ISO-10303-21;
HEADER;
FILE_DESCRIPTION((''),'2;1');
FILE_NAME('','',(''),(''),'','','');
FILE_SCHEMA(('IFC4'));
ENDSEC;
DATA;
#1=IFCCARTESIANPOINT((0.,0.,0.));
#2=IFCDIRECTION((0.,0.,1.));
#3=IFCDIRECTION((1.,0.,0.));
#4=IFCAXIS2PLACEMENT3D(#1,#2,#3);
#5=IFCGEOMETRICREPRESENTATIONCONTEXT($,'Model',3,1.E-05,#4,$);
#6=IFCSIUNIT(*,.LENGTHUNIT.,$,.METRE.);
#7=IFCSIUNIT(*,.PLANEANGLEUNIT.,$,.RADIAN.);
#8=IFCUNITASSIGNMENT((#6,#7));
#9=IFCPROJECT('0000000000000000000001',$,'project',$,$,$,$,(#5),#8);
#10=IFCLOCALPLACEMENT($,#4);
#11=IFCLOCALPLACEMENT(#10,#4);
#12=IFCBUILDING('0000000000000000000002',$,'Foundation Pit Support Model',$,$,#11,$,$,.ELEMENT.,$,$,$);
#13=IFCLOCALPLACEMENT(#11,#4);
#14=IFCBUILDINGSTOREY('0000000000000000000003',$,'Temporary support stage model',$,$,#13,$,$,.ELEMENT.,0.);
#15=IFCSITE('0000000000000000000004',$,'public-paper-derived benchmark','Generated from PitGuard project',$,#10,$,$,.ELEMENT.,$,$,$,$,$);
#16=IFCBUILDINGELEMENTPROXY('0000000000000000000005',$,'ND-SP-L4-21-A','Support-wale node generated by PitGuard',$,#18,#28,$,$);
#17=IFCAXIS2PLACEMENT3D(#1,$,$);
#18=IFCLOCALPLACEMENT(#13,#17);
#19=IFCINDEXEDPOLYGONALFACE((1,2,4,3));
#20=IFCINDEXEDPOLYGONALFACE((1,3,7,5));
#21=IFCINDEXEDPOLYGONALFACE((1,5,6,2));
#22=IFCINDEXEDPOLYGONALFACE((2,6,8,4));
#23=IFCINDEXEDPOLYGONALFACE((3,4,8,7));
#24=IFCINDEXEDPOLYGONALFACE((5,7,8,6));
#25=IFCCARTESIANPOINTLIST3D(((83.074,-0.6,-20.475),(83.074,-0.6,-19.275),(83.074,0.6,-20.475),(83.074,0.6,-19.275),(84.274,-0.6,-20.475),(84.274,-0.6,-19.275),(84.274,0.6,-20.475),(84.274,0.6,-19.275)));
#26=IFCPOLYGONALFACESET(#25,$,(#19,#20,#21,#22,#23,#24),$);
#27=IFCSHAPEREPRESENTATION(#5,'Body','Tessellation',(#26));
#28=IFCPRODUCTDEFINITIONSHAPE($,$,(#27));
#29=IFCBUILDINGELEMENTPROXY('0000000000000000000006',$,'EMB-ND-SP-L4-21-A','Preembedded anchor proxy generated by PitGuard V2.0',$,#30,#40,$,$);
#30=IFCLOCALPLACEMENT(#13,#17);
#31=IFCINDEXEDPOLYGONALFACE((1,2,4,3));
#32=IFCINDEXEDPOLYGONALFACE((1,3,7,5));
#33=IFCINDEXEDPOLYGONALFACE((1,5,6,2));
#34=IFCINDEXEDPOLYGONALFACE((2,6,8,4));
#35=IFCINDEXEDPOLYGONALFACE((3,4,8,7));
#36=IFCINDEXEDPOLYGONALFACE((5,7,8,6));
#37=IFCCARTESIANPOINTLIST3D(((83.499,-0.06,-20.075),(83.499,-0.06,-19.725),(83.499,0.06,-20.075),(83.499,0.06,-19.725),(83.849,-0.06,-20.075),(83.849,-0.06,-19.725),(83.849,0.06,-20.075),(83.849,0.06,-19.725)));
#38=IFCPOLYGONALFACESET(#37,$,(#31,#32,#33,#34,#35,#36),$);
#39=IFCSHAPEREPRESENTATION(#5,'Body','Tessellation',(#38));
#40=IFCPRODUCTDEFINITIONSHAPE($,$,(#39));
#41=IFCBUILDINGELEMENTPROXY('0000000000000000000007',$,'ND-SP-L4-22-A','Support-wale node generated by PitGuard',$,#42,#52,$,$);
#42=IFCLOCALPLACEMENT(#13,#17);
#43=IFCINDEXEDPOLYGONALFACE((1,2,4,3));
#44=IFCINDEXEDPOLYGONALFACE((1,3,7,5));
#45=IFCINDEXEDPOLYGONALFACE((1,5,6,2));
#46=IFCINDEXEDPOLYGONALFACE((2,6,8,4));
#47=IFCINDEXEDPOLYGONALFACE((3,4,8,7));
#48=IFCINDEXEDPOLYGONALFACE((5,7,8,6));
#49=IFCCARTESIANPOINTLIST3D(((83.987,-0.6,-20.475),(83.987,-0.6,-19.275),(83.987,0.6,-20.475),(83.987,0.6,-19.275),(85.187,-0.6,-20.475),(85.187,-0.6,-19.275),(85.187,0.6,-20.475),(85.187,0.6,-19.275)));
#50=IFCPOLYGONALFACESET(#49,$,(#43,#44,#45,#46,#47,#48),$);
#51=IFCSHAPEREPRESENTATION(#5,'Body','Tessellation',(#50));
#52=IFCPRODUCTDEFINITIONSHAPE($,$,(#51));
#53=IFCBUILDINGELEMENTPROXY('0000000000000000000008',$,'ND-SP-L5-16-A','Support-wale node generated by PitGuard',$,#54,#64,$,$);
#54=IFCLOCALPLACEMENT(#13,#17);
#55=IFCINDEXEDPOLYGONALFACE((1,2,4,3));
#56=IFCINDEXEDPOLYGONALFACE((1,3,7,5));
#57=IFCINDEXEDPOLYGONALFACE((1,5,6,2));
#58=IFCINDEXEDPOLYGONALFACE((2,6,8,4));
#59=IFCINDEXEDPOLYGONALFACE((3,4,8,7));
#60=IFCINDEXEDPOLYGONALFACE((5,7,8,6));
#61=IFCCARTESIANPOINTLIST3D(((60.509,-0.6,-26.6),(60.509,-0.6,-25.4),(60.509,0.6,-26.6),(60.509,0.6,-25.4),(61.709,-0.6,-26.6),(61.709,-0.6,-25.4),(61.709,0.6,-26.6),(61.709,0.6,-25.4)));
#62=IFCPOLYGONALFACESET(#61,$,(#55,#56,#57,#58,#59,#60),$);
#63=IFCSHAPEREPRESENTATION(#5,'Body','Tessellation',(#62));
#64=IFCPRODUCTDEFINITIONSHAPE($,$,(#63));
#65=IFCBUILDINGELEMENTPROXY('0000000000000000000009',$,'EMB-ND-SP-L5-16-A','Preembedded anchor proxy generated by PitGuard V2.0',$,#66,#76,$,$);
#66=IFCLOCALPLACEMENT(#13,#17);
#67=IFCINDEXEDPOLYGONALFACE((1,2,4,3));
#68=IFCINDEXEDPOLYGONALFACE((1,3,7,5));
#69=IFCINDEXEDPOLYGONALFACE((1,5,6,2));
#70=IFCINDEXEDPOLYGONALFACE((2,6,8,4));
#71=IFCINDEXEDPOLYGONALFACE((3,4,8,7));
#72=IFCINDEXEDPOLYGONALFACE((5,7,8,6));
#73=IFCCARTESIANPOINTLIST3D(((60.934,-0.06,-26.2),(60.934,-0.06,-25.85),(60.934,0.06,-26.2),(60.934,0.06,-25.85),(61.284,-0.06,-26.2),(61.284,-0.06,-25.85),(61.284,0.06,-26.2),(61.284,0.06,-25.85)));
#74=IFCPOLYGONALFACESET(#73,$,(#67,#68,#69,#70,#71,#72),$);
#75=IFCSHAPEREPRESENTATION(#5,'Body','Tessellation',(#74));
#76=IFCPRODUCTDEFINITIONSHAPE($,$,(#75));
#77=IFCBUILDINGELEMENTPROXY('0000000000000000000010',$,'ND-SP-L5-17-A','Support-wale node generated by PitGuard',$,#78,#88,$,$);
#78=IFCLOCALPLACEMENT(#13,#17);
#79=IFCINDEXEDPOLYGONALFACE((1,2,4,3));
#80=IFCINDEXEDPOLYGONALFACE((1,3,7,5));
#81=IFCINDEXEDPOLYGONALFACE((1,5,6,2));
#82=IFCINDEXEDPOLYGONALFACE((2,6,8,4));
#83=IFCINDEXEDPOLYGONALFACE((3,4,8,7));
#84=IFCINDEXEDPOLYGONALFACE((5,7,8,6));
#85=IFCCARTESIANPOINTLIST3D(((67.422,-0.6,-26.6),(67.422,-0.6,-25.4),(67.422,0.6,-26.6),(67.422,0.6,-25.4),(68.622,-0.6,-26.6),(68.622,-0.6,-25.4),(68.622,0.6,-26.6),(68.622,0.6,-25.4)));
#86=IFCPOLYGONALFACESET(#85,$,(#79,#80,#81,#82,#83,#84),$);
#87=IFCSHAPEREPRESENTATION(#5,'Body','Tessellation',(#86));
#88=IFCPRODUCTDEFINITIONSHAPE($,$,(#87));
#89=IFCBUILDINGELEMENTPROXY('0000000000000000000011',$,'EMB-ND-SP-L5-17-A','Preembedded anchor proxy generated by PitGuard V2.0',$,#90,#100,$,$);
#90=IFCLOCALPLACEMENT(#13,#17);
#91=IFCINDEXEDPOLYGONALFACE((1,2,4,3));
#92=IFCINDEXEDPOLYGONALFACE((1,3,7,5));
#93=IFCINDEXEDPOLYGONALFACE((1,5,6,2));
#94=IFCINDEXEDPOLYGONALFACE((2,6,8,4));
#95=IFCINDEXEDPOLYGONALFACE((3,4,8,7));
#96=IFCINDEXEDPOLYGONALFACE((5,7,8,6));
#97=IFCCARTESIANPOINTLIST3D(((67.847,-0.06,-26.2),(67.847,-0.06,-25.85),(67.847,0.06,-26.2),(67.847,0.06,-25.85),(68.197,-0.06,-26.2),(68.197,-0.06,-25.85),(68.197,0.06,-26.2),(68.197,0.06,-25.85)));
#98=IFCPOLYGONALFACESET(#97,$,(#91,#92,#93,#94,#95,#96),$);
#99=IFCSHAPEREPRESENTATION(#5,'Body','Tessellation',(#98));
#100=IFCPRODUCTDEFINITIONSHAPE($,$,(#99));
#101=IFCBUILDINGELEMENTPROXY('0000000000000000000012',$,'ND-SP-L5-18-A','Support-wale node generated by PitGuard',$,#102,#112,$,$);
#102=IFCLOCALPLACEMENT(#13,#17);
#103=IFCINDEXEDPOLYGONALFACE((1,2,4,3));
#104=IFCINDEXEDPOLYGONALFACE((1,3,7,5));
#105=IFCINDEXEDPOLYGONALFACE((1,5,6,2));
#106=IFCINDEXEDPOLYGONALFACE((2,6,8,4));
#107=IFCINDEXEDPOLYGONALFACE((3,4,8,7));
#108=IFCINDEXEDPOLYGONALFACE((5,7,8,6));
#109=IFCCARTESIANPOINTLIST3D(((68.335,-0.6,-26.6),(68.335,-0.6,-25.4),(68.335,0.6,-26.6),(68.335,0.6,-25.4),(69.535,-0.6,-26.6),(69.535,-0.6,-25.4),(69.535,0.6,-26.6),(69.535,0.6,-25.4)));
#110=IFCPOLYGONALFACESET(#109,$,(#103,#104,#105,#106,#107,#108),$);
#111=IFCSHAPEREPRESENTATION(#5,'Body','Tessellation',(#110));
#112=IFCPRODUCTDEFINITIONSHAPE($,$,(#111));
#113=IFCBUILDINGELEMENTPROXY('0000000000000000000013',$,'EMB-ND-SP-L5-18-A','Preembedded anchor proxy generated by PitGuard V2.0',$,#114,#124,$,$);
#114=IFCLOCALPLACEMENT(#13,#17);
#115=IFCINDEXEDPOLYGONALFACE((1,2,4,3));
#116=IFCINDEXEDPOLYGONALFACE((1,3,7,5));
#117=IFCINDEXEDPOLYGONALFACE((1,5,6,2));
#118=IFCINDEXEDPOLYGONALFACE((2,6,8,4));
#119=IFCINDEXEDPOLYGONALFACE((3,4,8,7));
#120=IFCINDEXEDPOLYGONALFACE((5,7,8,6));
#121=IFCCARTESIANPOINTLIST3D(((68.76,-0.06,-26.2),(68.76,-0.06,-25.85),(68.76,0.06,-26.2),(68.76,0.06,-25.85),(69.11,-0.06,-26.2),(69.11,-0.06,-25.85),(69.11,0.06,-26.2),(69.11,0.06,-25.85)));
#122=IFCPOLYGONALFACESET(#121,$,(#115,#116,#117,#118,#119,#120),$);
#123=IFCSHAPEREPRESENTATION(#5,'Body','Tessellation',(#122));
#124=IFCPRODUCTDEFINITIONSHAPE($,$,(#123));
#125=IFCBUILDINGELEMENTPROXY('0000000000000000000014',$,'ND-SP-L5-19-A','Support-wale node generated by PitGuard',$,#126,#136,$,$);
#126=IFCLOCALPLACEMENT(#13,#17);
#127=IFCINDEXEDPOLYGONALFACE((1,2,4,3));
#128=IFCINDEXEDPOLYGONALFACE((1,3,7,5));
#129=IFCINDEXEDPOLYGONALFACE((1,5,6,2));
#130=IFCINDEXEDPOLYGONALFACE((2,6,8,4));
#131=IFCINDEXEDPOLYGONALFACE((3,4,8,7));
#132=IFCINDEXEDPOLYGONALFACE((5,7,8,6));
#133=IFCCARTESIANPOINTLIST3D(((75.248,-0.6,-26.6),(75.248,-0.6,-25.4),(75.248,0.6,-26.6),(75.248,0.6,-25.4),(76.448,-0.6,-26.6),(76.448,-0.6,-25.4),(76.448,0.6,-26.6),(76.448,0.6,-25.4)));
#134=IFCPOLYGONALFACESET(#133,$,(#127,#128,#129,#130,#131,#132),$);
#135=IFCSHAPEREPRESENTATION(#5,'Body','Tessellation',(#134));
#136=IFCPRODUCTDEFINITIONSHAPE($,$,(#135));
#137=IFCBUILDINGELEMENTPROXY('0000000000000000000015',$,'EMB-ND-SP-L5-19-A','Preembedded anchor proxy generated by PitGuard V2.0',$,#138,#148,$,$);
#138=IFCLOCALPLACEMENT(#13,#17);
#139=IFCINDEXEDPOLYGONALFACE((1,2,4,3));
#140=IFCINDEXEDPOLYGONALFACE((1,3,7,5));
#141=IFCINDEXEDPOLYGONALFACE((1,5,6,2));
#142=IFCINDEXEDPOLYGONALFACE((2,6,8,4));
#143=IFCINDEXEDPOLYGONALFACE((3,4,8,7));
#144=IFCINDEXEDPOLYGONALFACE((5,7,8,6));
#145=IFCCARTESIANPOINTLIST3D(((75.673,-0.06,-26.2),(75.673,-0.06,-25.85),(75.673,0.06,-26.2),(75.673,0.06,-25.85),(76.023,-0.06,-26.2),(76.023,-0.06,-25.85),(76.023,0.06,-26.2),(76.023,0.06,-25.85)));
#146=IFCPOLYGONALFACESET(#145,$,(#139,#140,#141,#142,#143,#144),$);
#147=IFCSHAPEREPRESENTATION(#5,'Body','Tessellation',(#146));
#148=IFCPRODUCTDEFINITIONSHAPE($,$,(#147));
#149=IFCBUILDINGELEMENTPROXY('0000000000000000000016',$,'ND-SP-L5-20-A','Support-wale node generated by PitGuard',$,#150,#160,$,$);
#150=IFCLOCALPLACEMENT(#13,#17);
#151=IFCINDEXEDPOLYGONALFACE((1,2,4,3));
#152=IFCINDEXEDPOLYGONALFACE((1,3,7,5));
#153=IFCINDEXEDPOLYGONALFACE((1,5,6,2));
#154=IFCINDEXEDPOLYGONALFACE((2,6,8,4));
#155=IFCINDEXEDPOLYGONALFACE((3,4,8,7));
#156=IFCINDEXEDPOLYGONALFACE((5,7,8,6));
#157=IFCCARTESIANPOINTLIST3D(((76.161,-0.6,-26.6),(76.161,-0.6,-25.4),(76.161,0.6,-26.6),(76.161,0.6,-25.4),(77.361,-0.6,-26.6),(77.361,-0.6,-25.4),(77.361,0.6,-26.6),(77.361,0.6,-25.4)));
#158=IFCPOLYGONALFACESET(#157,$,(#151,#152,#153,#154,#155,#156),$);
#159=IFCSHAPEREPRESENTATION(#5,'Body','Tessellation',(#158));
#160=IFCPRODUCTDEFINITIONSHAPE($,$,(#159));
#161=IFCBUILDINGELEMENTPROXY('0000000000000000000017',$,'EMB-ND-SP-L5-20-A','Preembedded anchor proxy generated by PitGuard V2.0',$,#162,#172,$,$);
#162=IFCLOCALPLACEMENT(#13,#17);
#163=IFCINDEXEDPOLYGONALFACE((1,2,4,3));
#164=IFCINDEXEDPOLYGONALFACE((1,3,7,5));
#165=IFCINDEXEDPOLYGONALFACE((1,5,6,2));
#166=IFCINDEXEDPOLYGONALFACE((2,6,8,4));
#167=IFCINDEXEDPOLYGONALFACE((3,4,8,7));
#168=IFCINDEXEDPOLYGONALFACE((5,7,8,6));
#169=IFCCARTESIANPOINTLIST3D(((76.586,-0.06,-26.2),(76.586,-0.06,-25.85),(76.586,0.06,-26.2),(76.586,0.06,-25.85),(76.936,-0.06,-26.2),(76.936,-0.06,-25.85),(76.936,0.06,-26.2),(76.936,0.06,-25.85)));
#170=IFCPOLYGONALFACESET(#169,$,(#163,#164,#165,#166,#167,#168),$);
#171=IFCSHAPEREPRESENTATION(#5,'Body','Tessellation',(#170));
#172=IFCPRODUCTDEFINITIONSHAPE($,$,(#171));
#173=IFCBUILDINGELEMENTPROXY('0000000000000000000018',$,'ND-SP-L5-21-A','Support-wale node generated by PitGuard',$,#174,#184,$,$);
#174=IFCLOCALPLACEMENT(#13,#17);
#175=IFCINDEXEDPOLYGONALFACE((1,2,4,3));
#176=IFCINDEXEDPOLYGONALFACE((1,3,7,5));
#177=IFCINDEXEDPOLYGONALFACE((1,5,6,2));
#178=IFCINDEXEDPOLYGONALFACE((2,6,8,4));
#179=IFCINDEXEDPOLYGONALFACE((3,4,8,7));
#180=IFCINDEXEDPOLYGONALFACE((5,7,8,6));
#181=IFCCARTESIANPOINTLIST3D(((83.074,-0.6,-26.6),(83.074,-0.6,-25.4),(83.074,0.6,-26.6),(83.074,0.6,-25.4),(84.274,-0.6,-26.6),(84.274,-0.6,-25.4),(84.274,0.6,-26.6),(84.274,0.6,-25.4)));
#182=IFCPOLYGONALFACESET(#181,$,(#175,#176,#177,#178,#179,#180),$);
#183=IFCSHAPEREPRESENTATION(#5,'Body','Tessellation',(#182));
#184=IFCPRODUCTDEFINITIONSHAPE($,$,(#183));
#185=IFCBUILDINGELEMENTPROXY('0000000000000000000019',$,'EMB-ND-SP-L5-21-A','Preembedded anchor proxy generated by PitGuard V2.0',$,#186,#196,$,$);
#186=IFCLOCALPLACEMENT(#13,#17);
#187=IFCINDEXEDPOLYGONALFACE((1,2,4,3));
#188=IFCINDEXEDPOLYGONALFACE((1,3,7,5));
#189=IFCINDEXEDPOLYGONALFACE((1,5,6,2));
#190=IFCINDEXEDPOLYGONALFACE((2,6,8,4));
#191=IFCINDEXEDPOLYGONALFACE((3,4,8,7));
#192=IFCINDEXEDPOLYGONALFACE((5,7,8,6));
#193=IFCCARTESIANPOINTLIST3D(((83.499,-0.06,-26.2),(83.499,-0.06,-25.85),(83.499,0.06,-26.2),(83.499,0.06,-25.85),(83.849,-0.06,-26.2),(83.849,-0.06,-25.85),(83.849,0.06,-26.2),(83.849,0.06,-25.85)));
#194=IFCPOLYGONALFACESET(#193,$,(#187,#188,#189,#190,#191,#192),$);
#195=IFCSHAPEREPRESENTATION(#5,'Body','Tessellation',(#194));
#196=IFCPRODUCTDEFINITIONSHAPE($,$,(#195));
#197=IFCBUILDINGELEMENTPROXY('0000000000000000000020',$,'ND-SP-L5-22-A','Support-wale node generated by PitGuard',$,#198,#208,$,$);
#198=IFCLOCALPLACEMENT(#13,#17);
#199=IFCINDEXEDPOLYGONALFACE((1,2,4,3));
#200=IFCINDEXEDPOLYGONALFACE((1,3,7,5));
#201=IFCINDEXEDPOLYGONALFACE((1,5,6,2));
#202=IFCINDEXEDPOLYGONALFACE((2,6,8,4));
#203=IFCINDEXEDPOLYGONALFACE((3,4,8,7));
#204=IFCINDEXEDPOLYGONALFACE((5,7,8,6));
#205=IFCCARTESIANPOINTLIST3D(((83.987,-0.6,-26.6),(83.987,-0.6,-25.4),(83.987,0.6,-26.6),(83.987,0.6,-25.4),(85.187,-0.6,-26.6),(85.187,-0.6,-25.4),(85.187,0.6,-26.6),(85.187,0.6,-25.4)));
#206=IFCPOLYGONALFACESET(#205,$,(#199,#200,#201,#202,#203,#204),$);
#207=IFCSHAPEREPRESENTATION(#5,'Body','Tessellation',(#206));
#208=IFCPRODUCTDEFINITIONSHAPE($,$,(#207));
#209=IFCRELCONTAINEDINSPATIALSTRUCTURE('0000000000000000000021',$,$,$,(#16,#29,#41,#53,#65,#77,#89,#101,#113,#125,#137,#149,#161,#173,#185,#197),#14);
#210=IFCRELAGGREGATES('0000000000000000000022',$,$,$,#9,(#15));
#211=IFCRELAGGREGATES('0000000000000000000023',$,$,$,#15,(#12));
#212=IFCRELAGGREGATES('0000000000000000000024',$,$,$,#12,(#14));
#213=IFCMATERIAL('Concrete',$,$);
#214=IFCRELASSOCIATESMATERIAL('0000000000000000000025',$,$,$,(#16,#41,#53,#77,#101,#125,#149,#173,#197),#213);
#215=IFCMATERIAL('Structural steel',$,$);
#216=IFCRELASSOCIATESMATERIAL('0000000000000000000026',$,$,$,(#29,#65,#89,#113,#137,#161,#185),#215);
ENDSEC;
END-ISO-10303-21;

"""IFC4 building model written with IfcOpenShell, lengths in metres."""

from ifc_helpers import new_model, si_unit, frame, origin_with_axes, origin_2d, place, context, project, spatial, rectangle, extrude, material, element, save


model = new_model("IFC4")

# Units and contexts
model_context = context("Model", 3, precision=1e-05, world=origin_with_axes())
ifc_project = project(units=[si_unit("LENGTHUNIT", "METRE"), si_unit("PLANEANGLEUNIT", "RADIAN")], contexts=[model_context])

# Site, building, storey
site_placement = place(None, origin_with_axes())
site = spatial("IfcSite", under=ifc_project, at=site_placement, Name="public-paper-derived benchmark", Description="Generated from PitGuard project", CompositionType="ELEMENT")
building_placement = place(site_placement, origin_with_axes())
building = spatial("IfcBuilding", under=site, at=building_placement, Name="Foundation Pit Support Model", CompositionType="ELEMENT")
storey_placement = place(building_placement, origin_with_axes())
storey = spatial("IfcBuildingStorey", under=building, at=storey_placement, Name="Temporary support stage model", CompositionType="ELEMENT", Elevation=0.0)

# Shared definitions
ifc_material_1 = material(Name="Structural steel")

# Building element proxies
ifc_material_2 = material(Name="Concrete")
proxy_1_placement = place(storey_placement, frame((83.674, 0.0, -20.475), z_axis=(0.0, 0.0, 1.0), x_axis=(1.0, 0.0, 0.0)))
element("IfcBuildingElementProxy", 1, at=proxy_1_placement, inside=storey, material=ifc_material_2, Name="ND-SP-L4-21-A", Description="Support-wale node generated by PitGuard", context=model_context, shape_type="SweptSolid", body=[
    extrude(rectangle(XDim=1.2, YDim=1.2, at=origin_2d()), origin_with_axes(), (0.0, 0.0, 1.0), 1.2),
])
proxy_2_placement = place(storey_placement, frame((83.674, 0.0, -20.075), z_axis=(0.0, 0.0, 1.0), x_axis=(1.0, 0.0, 0.0)))
element("IfcBuildingElementProxy", 2, at=proxy_2_placement, inside=storey, material=ifc_material_1, Name="EMB-ND-SP-L4-21-A", Description="Preembedded anchor proxy generated by PitGuard V2.0", context=model_context, shape_type="SweptSolid", body=[
    extrude(rectangle(XDim=0.35, YDim=0.12, at=origin_2d()), origin_with_axes(), (0.0, 0.0, 1.0), 0.35),
])
for number, where, z_axis, x_axis, name in (
    (3, (84.587, 0.0, -20.475), (0.0, 0.0, 1.0), (1.0, 0.0, 0.0), "ND-SP-L4-22-A"),
    (4, (61.109, 0.0, -26.6), (0.0, 0.0, 1.0), (1.0, 0.0, 0.0), "ND-SP-L5-16-A"),
):
    element("IfcBuildingElementProxy", number, at=place(storey_placement, frame(where, z_axis=z_axis, x_axis=x_axis)), inside=storey, material=ifc_material_2, Name=name, Description="Support-wale node generated by PitGuard", context=model_context, shape_type="SweptSolid", body=[
        extrude(rectangle(XDim=1.2, YDim=1.2, at=origin_2d()), origin_with_axes(), (0.0, 0.0, 1.0), 1.2),
    ])
proxy_3_placement = place(storey_placement, frame((61.109, 0.0, -26.2), z_axis=(0.0, 0.0, 1.0), x_axis=(1.0, 0.0, 0.0)))
element("IfcBuildingElementProxy", 5, at=proxy_3_placement, inside=storey, material=ifc_material_1, Name="EMB-ND-SP-L5-16-A", Description="Preembedded anchor proxy generated by PitGuard V2.0", context=model_context, shape_type="SweptSolid", body=[
    extrude(rectangle(XDim=0.35, YDim=0.12, at=origin_2d()), origin_with_axes(), (0.0, 0.0, 1.0), 0.35),
])
proxy_4_placement = place(storey_placement, frame((68.022, 0.0, -26.6), z_axis=(0.0, 0.0, 1.0), x_axis=(1.0, 0.0, 0.0)))
element("IfcBuildingElementProxy", 6, at=proxy_4_placement, inside=storey, material=ifc_material_2, Name="ND-SP-L5-17-A", Description="Support-wale node generated by PitGuard", context=model_context, shape_type="SweptSolid", body=[
    extrude(rectangle(XDim=1.2, YDim=1.2, at=origin_2d()), origin_with_axes(), (0.0, 0.0, 1.0), 1.2),
])
proxy_5_placement = place(storey_placement, frame((68.022, 0.0, -26.2), z_axis=(0.0, 0.0, 1.0), x_axis=(1.0, 0.0, 0.0)))
element("IfcBuildingElementProxy", 7, at=proxy_5_placement, inside=storey, material=ifc_material_1, Name="EMB-ND-SP-L5-17-A", Description="Preembedded anchor proxy generated by PitGuard V2.0", context=model_context, shape_type="SweptSolid", body=[
    extrude(rectangle(XDim=0.35, YDim=0.12, at=origin_2d()), origin_with_axes(), (0.0, 0.0, 1.0), 0.35),
])
proxy_6_placement = place(storey_placement, frame((68.935, 0.0, -26.6), z_axis=(0.0, 0.0, 1.0), x_axis=(1.0, 0.0, 0.0)))
element("IfcBuildingElementProxy", 8, at=proxy_6_placement, inside=storey, material=ifc_material_2, Name="ND-SP-L5-18-A", Description="Support-wale node generated by PitGuard", context=model_context, shape_type="SweptSolid", body=[
    extrude(rectangle(XDim=1.2, YDim=1.2, at=origin_2d()), origin_with_axes(), (0.0, 0.0, 1.0), 1.2),
])
proxy_7_placement = place(storey_placement, frame((68.935, 0.0, -26.2), z_axis=(0.0, 0.0, 1.0), x_axis=(1.0, 0.0, 0.0)))
element("IfcBuildingElementProxy", 9, at=proxy_7_placement, inside=storey, material=ifc_material_1, Name="EMB-ND-SP-L5-18-A", Description="Preembedded anchor proxy generated by PitGuard V2.0", context=model_context, shape_type="SweptSolid", body=[
    extrude(rectangle(XDim=0.35, YDim=0.12, at=origin_2d()), origin_with_axes(), (0.0, 0.0, 1.0), 0.35),
])
proxy_8_placement = place(storey_placement, frame((75.848, 0.0, -26.6), z_axis=(0.0, 0.0, 1.0), x_axis=(1.0, 0.0, 0.0)))
element("IfcBuildingElementProxy", 10, at=proxy_8_placement, inside=storey, material=ifc_material_2, Name="ND-SP-L5-19-A", Description="Support-wale node generated by PitGuard", context=model_context, shape_type="SweptSolid", body=[
    extrude(rectangle(XDim=1.2, YDim=1.2, at=origin_2d()), origin_with_axes(), (0.0, 0.0, 1.0), 1.2),
])
proxy_9_placement = place(storey_placement, frame((75.848, 0.0, -26.2), z_axis=(0.0, 0.0, 1.0), x_axis=(1.0, 0.0, 0.0)))
element("IfcBuildingElementProxy", 11, at=proxy_9_placement, inside=storey, material=ifc_material_1, Name="EMB-ND-SP-L5-19-A", Description="Preembedded anchor proxy generated by PitGuard V2.0", context=model_context, shape_type="SweptSolid", body=[
    extrude(rectangle(XDim=0.35, YDim=0.12, at=origin_2d()), origin_with_axes(), (0.0, 0.0, 1.0), 0.35),
])
proxy_10_placement = place(storey_placement, frame((76.761, 0.0, -26.6), z_axis=(0.0, 0.0, 1.0), x_axis=(1.0, 0.0, 0.0)))
element("IfcBuildingElementProxy", 12, at=proxy_10_placement, inside=storey, material=ifc_material_2, Name="ND-SP-L5-20-A", Description="Support-wale node generated by PitGuard", context=model_context, shape_type="SweptSolid", body=[
    extrude(rectangle(XDim=1.2, YDim=1.2, at=origin_2d()), origin_with_axes(), (0.0, 0.0, 1.0), 1.2),
])
proxy_11_placement = place(storey_placement, frame((76.761, 0.0, -26.2), z_axis=(0.0, 0.0, 1.0), x_axis=(1.0, 0.0, 0.0)))
element("IfcBuildingElementProxy", 13, at=proxy_11_placement, inside=storey, material=ifc_material_1, Name="EMB-ND-SP-L5-20-A", Description="Preembedded anchor proxy generated by PitGuard V2.0", context=model_context, shape_type="SweptSolid", body=[
    extrude(rectangle(XDim=0.35, YDim=0.12, at=origin_2d()), origin_with_axes(), (0.0, 0.0, 1.0), 0.35),
])
proxy_12_placement = place(storey_placement, frame((83.674, 0.0, -26.6), z_axis=(0.0, 0.0, 1.0), x_axis=(1.0, 0.0, 0.0)))
element("IfcBuildingElementProxy", 14, at=proxy_12_placement, inside=storey, material=ifc_material_2, Name="ND-SP-L5-21-A", Description="Support-wale node generated by PitGuard", context=model_context, shape_type="SweptSolid", body=[
    extrude(rectangle(XDim=1.2, YDim=1.2, at=origin_2d()), origin_with_axes(), (0.0, 0.0, 1.0), 1.2),
])
proxy_13_placement = place(storey_placement, frame((83.674, 0.0, -26.2), z_axis=(0.0, 0.0, 1.0), x_axis=(1.0, 0.0, 0.0)))
element("IfcBuildingElementProxy", 15, at=proxy_13_placement, inside=storey, material=ifc_material_1, Name="EMB-ND-SP-L5-21-A", Description="Preembedded anchor proxy generated by PitGuard V2.0", context=model_context, shape_type="SweptSolid", body=[
    extrude(rectangle(XDim=0.35, YDim=0.12, at=origin_2d()), origin_with_axes(), (0.0, 0.0, 1.0), 0.35),
])
proxy_14_placement = place(storey_placement, frame((84.587, 0.0, -26.6), z_axis=(0.0, 0.0, 1.0), x_axis=(1.0, 0.0, 0.0)))
element("IfcBuildingElementProxy", 16, at=proxy_14_placement, inside=storey, material=ifc_material_2, Name="ND-SP-L5-22-A", Description="Support-wale node generated by PitGuard", context=model_context, shape_type="SweptSolid", body=[
    extrude(rectangle(XDim=1.2, YDim=1.2, at=origin_2d()), origin_with_axes(), (0.0, 0.0, 1.0), 1.2),
])

save(model, "model.ifc")
